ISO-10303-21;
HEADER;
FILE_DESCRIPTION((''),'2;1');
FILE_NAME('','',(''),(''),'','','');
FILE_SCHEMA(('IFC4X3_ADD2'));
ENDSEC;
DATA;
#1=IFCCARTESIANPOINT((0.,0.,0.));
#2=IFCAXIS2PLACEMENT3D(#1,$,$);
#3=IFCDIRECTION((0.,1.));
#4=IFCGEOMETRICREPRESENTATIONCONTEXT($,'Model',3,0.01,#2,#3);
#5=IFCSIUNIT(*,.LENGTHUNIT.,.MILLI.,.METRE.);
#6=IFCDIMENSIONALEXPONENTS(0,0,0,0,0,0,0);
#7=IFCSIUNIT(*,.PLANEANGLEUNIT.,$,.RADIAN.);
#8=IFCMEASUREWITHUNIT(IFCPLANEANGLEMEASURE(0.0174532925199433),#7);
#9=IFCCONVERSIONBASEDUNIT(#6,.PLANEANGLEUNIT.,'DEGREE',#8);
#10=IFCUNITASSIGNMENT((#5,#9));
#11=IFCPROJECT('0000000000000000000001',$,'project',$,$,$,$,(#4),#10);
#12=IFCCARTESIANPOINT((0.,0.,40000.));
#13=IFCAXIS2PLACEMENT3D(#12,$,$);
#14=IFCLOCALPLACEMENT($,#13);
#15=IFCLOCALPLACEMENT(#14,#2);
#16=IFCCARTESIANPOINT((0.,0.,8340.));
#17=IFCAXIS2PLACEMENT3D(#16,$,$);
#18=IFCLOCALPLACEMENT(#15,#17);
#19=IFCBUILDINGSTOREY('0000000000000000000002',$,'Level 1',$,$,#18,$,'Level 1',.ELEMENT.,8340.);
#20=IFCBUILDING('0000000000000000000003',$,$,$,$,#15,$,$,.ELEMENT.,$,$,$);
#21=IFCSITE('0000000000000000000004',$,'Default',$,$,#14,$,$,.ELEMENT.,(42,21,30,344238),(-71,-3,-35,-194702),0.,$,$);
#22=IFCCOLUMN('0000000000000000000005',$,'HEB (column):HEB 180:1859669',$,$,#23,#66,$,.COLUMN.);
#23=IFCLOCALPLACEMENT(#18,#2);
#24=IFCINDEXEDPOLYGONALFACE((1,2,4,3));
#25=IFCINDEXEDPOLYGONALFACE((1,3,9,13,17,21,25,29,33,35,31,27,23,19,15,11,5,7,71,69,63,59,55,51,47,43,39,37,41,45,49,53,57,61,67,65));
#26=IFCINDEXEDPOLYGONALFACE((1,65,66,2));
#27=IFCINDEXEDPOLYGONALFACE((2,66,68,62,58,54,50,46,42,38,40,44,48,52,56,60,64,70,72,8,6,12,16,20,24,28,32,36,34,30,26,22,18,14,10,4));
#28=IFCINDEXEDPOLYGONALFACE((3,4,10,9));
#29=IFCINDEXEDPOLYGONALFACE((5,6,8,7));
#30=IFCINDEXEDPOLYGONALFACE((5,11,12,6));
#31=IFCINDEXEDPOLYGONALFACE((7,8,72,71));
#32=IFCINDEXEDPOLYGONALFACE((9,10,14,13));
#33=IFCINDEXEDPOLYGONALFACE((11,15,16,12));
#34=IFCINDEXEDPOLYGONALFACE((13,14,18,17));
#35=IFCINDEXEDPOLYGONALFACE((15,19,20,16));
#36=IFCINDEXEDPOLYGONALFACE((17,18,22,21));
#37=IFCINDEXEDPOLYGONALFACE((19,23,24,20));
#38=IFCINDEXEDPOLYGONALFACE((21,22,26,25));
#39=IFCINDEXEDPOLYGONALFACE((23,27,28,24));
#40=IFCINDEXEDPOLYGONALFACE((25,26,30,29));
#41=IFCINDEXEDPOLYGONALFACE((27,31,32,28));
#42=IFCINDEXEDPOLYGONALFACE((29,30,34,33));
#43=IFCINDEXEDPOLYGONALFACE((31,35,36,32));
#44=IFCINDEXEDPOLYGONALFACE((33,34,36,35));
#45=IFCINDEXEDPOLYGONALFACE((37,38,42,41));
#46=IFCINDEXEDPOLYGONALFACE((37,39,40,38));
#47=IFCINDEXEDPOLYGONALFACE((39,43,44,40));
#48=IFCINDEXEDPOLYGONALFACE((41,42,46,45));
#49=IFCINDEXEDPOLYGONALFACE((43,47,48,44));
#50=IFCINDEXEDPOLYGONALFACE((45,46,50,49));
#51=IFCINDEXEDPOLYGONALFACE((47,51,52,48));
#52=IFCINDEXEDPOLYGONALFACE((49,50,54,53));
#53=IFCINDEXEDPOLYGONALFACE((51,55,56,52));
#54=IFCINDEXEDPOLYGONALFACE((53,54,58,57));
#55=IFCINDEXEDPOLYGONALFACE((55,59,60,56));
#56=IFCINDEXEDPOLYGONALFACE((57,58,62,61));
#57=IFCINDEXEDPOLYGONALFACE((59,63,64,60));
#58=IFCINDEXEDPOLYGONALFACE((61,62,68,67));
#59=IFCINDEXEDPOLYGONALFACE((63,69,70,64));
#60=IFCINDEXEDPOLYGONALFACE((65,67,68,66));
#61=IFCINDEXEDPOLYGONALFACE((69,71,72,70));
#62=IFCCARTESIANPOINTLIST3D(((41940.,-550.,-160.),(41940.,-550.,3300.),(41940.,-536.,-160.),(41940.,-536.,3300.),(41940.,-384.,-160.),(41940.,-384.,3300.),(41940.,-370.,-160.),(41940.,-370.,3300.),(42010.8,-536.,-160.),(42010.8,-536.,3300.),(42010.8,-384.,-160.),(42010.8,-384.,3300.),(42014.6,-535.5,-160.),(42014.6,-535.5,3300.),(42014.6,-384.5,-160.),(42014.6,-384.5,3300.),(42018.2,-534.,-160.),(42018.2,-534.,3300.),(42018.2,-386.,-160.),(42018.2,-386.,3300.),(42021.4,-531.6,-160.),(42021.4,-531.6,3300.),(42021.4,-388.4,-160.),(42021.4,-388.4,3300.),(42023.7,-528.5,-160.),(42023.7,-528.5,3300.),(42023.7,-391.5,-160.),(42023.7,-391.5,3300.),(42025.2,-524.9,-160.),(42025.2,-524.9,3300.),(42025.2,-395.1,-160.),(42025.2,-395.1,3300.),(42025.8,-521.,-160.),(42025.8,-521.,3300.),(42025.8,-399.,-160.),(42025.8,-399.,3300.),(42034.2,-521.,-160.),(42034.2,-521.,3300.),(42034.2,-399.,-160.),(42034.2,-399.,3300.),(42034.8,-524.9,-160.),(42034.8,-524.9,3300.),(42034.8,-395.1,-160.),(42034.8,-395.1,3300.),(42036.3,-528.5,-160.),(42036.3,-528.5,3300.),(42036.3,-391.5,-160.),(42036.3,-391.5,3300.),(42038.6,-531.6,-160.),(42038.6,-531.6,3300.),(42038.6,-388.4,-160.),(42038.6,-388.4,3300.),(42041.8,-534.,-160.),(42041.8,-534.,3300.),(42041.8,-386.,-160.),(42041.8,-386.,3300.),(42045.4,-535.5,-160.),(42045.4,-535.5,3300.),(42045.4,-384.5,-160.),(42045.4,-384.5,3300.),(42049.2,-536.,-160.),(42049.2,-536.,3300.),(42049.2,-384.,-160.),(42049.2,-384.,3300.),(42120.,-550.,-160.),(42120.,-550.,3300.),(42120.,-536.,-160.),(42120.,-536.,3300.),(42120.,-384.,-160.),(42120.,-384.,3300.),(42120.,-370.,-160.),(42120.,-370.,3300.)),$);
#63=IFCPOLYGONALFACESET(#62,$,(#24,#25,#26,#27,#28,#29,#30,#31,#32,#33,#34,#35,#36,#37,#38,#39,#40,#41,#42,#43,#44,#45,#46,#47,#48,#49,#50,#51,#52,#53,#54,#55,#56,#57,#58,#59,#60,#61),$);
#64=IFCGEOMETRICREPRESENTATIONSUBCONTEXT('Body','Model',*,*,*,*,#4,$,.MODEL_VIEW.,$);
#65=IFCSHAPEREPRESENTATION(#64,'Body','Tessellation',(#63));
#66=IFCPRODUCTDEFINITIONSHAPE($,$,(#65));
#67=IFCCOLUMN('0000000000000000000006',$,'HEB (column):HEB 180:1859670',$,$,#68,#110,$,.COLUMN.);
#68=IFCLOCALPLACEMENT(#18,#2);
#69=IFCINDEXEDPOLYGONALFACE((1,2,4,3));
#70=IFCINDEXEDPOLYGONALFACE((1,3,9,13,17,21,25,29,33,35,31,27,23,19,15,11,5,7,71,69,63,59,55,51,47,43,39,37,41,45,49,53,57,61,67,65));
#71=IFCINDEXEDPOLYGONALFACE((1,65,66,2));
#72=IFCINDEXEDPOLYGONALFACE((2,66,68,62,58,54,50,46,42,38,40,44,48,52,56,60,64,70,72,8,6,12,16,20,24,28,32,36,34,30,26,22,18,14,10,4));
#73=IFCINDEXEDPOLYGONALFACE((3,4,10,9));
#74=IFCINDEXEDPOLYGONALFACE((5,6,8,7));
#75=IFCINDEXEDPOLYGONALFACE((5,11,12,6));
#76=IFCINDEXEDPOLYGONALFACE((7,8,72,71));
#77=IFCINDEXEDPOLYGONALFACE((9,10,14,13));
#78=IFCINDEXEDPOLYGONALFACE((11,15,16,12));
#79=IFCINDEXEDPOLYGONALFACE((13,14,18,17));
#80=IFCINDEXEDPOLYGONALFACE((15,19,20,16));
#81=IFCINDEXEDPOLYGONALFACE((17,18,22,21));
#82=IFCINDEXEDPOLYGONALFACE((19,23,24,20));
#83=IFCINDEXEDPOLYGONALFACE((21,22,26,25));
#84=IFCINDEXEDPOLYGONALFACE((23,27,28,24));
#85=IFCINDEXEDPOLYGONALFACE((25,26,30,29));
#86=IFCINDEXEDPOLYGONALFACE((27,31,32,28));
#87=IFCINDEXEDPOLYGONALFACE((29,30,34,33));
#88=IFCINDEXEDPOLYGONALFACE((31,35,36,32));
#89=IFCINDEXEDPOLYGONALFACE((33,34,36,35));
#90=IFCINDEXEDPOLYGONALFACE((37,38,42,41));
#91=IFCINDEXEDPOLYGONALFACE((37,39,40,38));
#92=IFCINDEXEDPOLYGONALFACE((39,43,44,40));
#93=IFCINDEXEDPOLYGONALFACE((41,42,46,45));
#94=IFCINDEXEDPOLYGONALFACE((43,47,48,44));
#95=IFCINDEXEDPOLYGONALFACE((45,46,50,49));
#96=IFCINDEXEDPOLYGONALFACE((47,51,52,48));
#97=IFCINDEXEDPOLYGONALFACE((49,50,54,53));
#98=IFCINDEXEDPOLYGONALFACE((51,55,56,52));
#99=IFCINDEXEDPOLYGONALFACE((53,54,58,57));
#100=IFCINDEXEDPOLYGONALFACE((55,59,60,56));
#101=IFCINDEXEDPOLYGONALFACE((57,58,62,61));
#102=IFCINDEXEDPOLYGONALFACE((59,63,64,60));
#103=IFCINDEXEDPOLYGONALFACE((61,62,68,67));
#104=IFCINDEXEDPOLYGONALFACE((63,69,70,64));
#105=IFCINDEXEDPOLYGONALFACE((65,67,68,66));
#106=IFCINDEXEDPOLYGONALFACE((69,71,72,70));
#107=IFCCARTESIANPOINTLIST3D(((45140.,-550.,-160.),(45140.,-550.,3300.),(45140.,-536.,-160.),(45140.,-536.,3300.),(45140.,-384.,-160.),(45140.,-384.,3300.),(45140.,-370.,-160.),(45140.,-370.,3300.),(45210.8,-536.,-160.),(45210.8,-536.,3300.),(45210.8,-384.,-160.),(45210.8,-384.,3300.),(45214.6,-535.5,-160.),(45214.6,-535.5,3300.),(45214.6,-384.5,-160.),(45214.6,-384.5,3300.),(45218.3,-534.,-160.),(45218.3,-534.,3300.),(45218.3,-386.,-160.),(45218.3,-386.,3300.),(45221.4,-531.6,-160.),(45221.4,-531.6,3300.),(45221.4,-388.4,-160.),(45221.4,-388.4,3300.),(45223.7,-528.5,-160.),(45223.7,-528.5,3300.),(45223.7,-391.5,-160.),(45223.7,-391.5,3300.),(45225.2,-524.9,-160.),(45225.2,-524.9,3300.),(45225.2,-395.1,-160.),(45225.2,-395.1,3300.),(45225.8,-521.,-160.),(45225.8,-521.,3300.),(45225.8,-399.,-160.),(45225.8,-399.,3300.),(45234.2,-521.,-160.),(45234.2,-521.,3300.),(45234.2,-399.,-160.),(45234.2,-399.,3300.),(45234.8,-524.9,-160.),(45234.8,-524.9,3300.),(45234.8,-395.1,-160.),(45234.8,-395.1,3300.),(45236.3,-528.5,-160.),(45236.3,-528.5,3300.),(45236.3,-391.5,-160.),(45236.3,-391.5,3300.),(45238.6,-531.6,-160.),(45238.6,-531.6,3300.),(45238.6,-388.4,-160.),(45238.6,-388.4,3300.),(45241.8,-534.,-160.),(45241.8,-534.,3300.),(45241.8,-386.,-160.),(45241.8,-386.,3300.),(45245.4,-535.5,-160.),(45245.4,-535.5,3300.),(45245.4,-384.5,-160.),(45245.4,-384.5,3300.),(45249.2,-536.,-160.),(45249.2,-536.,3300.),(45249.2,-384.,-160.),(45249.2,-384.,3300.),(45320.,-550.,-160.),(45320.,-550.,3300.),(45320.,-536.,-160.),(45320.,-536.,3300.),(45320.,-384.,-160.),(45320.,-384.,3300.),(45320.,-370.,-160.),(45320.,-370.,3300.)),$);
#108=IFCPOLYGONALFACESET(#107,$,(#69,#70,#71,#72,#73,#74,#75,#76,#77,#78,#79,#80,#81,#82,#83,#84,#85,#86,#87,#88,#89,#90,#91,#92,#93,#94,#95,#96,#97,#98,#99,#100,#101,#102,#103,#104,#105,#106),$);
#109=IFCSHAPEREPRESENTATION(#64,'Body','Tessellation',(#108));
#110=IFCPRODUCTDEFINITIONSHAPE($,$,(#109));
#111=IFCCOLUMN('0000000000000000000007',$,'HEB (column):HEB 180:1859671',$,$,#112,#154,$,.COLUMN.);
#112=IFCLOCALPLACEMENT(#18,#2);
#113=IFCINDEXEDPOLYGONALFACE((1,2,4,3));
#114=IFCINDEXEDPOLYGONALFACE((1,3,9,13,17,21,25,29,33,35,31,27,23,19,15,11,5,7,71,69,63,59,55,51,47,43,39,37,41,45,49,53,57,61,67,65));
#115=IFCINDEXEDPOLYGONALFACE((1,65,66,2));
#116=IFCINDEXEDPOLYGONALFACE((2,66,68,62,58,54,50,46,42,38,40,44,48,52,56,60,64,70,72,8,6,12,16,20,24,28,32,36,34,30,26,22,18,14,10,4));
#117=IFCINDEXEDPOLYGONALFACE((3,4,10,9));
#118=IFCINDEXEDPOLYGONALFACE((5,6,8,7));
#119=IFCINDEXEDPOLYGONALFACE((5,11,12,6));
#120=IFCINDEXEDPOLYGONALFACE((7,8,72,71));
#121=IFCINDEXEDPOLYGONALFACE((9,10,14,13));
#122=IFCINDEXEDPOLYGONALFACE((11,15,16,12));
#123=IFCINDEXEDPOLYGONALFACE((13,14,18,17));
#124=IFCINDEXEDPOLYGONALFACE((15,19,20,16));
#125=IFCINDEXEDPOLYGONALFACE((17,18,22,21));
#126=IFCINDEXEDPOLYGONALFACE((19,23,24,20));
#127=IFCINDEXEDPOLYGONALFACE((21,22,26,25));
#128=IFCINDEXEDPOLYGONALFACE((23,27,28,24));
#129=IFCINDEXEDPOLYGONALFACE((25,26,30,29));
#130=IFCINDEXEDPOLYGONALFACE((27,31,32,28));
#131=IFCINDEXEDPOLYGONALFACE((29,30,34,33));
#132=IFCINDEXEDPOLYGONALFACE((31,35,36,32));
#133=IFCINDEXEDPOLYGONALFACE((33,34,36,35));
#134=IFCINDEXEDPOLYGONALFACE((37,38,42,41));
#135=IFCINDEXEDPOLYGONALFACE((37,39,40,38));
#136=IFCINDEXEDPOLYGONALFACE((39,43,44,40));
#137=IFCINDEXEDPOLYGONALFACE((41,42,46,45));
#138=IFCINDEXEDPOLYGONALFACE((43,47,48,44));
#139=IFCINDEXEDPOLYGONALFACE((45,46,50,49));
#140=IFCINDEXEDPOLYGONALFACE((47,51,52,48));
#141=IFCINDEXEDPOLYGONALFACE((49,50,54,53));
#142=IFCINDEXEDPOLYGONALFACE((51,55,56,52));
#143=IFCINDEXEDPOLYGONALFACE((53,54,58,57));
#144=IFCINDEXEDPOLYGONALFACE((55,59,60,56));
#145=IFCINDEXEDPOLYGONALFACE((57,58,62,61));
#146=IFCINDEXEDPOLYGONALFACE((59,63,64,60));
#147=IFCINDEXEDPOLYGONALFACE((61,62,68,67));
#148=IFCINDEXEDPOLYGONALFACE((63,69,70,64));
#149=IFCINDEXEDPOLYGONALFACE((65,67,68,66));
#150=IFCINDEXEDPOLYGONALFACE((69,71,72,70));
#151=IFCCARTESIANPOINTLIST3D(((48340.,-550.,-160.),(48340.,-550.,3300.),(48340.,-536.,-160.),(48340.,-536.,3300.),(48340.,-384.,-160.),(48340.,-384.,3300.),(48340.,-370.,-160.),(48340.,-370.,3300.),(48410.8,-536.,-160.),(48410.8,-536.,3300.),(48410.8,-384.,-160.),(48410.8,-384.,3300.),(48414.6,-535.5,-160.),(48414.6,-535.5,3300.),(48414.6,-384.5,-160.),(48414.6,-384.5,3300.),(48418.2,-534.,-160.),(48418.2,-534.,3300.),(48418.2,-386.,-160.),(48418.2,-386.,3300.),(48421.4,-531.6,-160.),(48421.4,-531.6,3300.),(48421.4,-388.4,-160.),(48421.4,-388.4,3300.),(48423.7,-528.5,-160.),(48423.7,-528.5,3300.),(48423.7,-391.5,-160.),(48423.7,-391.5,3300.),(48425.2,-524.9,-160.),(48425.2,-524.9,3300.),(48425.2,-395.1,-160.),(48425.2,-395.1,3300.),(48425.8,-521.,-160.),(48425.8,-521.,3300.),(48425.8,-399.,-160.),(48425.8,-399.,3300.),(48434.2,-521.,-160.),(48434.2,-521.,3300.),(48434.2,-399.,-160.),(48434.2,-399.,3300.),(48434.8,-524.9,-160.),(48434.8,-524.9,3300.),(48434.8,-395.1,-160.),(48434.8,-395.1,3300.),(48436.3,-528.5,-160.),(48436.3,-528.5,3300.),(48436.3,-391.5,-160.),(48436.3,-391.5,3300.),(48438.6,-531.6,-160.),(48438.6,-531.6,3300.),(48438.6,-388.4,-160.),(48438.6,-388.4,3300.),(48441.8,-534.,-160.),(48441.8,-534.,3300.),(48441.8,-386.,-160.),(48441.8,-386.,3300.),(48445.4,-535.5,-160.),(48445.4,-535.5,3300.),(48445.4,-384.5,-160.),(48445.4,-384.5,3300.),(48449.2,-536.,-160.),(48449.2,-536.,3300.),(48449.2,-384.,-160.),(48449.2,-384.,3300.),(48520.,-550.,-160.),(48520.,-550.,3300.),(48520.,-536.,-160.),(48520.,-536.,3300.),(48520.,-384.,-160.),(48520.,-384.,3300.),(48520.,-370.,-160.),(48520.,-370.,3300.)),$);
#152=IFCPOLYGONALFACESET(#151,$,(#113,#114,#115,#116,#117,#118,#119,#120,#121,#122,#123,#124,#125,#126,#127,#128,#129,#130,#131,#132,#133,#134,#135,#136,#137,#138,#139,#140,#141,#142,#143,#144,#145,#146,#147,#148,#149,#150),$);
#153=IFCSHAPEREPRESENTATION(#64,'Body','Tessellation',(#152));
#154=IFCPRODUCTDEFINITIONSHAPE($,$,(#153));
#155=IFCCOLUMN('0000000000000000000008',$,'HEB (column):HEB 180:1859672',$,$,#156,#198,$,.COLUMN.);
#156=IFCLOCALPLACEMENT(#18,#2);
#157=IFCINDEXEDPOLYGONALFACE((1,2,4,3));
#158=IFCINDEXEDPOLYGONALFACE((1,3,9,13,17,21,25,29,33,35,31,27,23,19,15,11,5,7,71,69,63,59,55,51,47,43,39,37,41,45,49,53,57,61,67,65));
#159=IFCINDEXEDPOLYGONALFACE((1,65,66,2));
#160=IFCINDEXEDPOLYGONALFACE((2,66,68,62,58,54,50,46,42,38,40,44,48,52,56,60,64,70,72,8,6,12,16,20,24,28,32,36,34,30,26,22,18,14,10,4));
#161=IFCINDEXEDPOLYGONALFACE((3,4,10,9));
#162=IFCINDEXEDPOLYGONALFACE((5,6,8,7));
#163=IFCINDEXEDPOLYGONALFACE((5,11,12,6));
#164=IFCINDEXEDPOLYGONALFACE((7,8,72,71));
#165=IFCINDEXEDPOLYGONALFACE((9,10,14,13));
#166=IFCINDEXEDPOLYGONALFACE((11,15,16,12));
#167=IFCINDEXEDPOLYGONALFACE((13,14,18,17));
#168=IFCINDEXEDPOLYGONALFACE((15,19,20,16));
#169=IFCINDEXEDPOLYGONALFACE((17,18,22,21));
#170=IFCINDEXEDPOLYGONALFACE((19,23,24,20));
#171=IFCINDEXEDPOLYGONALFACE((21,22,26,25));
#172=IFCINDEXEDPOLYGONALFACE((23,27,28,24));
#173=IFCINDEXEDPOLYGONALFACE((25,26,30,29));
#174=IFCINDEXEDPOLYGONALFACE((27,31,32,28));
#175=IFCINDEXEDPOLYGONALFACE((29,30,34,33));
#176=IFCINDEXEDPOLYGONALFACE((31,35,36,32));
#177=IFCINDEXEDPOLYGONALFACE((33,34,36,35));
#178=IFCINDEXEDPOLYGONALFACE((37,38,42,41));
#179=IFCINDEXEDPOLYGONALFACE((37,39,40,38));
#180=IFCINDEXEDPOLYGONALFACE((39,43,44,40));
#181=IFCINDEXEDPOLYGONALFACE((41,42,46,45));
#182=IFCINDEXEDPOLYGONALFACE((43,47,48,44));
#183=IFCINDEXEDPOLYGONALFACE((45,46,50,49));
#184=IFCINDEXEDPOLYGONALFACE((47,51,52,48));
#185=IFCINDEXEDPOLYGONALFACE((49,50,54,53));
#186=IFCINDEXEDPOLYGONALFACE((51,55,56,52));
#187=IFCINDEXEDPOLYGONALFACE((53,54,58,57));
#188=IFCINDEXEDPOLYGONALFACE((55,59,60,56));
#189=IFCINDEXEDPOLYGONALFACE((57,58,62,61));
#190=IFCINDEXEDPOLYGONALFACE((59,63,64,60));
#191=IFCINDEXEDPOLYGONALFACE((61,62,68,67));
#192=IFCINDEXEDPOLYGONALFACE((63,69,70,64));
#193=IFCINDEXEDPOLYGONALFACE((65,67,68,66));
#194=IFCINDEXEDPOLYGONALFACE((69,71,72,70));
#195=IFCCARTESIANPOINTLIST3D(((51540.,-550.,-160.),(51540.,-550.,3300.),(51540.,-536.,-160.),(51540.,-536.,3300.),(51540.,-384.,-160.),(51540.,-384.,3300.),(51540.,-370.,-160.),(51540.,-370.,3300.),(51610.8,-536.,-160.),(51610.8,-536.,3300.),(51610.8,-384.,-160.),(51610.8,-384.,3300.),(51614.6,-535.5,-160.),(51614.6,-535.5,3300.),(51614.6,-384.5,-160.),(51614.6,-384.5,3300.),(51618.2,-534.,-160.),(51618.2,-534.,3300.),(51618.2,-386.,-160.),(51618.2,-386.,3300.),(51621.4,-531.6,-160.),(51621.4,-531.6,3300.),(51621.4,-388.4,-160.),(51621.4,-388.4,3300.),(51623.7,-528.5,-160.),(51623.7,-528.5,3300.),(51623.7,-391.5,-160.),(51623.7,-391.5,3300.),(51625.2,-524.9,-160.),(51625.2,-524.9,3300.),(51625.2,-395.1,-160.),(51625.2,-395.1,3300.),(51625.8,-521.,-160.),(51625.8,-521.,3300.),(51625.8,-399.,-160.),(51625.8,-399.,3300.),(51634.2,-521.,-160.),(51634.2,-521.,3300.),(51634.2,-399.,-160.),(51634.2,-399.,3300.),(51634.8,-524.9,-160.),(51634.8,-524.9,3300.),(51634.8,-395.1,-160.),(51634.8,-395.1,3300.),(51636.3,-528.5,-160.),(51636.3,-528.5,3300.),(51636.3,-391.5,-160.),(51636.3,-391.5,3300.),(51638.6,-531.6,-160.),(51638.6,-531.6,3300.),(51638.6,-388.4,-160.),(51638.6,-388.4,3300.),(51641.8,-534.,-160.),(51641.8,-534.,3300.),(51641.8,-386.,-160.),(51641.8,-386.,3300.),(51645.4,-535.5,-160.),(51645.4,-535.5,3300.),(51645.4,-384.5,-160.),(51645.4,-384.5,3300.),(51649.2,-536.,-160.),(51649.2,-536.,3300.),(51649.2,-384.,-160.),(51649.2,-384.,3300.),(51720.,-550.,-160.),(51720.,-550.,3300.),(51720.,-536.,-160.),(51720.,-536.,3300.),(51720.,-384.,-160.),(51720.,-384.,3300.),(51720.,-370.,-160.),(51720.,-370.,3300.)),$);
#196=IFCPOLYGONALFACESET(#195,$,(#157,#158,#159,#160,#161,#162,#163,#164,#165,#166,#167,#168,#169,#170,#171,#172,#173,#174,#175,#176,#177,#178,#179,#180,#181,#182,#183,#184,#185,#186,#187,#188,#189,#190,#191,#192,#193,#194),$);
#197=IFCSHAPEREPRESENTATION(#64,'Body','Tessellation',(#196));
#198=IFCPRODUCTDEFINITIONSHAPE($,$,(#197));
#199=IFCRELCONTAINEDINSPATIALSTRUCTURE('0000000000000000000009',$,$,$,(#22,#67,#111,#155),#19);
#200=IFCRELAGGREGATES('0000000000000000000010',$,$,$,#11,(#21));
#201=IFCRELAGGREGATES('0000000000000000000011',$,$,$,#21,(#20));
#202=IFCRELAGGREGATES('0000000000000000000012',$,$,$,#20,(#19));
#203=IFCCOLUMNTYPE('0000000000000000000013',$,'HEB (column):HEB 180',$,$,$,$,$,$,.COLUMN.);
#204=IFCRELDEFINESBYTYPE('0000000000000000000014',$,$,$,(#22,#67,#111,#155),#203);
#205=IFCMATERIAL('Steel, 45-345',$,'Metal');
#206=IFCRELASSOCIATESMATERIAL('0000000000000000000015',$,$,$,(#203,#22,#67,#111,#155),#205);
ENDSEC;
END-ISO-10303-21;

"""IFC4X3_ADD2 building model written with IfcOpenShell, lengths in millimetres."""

from ifc_helpers import new_model, entity, si_unit, converted_unit, direction, frame, origin, origin_2d_with_axis, place, context, subcontext, project, spatial, i_section, extrude, source, transform, mapped, material, material_profile, profile_set, profile_usage, type_object, type_shapes, element, save


model = new_model("IFC4X3_ADD2")

# Units and contexts
model_context = context("Model", 3, precision=0.01, world=origin(), true_north=direction((0.0, 1.0)))
body_context = subcontext(model_context, "Body", "Model", "MODEL_VIEW")
ifc_project = project(units=[si_unit("LENGTHUNIT", "METRE", prefix="MILLI"), converted_unit("PLANEANGLEUNIT", "DEGREE", entity("IfcPlaneAngleMeasure", 0.0174532925199433), si_unit("PLANEANGLEUNIT", "RADIAN"), dimensions=[0, 0, 0, 0, 0, 0, 0])], contexts=[model_context])

# Site, building, storey
site_placement = place(None, frame((0.0, 0.0, 40000.0)))
site = spatial("IfcSite", under=ifc_project, at=site_placement, Name="Default", CompositionType="ELEMENT", RefLatitude=(42, 21, 30, 344238), RefLongitude=(-71, -3, -35, -194702), RefElevation=0.0)
building_placement = place(site_placement, origin())
building = spatial("IfcBuilding", under=site, at=building_placement, CompositionType="ELEMENT")
storey_placement = place(building_placement, frame((0.0, 0.0, 8340.0)))
storey = spatial("IfcBuildingStorey", under=building, at=storey_placement, Name="Level 1", LongName="Level 1", CompositionType="ELEMENT", Elevation=8340.0)

# Columns
ifc_material = material(Name="Steel, 45-345", Category="Metal")
ifc_material_profile_1 = material_profile(ifc_material, i_section(OverallWidth=180.0, OverallDepth=180.0, WebThickness=8.5, FlangeThickness=14.0, FilletRadius=15.0, at=origin_2d_with_axis()), Name="HEB 180")
ifc_profile_set_1 = profile_set([ifc_material_profile_1], Name="HEB 180")
ifc_profile_usage_1 = profile_usage(ifc_profile_set_1)
column_type_1 = type_object("IfcColumnType", Name="HEB (column):HEB 180", PredefinedType="COLUMN", material=ifc_profile_set_1)
shared_shape_1 = source(origin(), body_context, "Body", "SweptSolid", [
    extrude(i_section(OverallWidth=180.0, OverallDepth=180.0, WebThickness=8.5, FlangeThickness=14.0, FilletRadius=15.0, at=origin_2d_with_axis()), frame((0.0, 0.0, 8180.0), z_axis=(0.0, 0.0, 1.0), x_axis=(-1.0, 0.0, 0.0)), (0.0, 0.0, 1.0), 3460.0),
])
type_shapes(column_type_1, [shared_shape_1])
for number, where, name in (
    (1, (42030.0, -460.0, -8340.0), "HEB (column):HEB 180:1859669"),
    (2, (45230.0, -460.0, -8340.0), "HEB (column):HEB 180:1859670"),
    (3, (48430.0, -460.0, -8340.0), "HEB (column):HEB 180:1859671"),
    (4, (51630.0, -460.0, -8340.0), "HEB (column):HEB 180:1859672"),
):
    element("IfcColumn", number, at=place(storey_placement, frame(where)), inside=storey, type_object=column_type_1, material=ifc_profile_usage_1, Name=name, PredefinedType="COLUMN", context=body_context, shape_type="MappedRepresentation", body=[
        mapped(shared_shape_1, transform((0.0, 0.0, 0.0), scale=1.0)),
    ])

save(model, "model.ifc")
